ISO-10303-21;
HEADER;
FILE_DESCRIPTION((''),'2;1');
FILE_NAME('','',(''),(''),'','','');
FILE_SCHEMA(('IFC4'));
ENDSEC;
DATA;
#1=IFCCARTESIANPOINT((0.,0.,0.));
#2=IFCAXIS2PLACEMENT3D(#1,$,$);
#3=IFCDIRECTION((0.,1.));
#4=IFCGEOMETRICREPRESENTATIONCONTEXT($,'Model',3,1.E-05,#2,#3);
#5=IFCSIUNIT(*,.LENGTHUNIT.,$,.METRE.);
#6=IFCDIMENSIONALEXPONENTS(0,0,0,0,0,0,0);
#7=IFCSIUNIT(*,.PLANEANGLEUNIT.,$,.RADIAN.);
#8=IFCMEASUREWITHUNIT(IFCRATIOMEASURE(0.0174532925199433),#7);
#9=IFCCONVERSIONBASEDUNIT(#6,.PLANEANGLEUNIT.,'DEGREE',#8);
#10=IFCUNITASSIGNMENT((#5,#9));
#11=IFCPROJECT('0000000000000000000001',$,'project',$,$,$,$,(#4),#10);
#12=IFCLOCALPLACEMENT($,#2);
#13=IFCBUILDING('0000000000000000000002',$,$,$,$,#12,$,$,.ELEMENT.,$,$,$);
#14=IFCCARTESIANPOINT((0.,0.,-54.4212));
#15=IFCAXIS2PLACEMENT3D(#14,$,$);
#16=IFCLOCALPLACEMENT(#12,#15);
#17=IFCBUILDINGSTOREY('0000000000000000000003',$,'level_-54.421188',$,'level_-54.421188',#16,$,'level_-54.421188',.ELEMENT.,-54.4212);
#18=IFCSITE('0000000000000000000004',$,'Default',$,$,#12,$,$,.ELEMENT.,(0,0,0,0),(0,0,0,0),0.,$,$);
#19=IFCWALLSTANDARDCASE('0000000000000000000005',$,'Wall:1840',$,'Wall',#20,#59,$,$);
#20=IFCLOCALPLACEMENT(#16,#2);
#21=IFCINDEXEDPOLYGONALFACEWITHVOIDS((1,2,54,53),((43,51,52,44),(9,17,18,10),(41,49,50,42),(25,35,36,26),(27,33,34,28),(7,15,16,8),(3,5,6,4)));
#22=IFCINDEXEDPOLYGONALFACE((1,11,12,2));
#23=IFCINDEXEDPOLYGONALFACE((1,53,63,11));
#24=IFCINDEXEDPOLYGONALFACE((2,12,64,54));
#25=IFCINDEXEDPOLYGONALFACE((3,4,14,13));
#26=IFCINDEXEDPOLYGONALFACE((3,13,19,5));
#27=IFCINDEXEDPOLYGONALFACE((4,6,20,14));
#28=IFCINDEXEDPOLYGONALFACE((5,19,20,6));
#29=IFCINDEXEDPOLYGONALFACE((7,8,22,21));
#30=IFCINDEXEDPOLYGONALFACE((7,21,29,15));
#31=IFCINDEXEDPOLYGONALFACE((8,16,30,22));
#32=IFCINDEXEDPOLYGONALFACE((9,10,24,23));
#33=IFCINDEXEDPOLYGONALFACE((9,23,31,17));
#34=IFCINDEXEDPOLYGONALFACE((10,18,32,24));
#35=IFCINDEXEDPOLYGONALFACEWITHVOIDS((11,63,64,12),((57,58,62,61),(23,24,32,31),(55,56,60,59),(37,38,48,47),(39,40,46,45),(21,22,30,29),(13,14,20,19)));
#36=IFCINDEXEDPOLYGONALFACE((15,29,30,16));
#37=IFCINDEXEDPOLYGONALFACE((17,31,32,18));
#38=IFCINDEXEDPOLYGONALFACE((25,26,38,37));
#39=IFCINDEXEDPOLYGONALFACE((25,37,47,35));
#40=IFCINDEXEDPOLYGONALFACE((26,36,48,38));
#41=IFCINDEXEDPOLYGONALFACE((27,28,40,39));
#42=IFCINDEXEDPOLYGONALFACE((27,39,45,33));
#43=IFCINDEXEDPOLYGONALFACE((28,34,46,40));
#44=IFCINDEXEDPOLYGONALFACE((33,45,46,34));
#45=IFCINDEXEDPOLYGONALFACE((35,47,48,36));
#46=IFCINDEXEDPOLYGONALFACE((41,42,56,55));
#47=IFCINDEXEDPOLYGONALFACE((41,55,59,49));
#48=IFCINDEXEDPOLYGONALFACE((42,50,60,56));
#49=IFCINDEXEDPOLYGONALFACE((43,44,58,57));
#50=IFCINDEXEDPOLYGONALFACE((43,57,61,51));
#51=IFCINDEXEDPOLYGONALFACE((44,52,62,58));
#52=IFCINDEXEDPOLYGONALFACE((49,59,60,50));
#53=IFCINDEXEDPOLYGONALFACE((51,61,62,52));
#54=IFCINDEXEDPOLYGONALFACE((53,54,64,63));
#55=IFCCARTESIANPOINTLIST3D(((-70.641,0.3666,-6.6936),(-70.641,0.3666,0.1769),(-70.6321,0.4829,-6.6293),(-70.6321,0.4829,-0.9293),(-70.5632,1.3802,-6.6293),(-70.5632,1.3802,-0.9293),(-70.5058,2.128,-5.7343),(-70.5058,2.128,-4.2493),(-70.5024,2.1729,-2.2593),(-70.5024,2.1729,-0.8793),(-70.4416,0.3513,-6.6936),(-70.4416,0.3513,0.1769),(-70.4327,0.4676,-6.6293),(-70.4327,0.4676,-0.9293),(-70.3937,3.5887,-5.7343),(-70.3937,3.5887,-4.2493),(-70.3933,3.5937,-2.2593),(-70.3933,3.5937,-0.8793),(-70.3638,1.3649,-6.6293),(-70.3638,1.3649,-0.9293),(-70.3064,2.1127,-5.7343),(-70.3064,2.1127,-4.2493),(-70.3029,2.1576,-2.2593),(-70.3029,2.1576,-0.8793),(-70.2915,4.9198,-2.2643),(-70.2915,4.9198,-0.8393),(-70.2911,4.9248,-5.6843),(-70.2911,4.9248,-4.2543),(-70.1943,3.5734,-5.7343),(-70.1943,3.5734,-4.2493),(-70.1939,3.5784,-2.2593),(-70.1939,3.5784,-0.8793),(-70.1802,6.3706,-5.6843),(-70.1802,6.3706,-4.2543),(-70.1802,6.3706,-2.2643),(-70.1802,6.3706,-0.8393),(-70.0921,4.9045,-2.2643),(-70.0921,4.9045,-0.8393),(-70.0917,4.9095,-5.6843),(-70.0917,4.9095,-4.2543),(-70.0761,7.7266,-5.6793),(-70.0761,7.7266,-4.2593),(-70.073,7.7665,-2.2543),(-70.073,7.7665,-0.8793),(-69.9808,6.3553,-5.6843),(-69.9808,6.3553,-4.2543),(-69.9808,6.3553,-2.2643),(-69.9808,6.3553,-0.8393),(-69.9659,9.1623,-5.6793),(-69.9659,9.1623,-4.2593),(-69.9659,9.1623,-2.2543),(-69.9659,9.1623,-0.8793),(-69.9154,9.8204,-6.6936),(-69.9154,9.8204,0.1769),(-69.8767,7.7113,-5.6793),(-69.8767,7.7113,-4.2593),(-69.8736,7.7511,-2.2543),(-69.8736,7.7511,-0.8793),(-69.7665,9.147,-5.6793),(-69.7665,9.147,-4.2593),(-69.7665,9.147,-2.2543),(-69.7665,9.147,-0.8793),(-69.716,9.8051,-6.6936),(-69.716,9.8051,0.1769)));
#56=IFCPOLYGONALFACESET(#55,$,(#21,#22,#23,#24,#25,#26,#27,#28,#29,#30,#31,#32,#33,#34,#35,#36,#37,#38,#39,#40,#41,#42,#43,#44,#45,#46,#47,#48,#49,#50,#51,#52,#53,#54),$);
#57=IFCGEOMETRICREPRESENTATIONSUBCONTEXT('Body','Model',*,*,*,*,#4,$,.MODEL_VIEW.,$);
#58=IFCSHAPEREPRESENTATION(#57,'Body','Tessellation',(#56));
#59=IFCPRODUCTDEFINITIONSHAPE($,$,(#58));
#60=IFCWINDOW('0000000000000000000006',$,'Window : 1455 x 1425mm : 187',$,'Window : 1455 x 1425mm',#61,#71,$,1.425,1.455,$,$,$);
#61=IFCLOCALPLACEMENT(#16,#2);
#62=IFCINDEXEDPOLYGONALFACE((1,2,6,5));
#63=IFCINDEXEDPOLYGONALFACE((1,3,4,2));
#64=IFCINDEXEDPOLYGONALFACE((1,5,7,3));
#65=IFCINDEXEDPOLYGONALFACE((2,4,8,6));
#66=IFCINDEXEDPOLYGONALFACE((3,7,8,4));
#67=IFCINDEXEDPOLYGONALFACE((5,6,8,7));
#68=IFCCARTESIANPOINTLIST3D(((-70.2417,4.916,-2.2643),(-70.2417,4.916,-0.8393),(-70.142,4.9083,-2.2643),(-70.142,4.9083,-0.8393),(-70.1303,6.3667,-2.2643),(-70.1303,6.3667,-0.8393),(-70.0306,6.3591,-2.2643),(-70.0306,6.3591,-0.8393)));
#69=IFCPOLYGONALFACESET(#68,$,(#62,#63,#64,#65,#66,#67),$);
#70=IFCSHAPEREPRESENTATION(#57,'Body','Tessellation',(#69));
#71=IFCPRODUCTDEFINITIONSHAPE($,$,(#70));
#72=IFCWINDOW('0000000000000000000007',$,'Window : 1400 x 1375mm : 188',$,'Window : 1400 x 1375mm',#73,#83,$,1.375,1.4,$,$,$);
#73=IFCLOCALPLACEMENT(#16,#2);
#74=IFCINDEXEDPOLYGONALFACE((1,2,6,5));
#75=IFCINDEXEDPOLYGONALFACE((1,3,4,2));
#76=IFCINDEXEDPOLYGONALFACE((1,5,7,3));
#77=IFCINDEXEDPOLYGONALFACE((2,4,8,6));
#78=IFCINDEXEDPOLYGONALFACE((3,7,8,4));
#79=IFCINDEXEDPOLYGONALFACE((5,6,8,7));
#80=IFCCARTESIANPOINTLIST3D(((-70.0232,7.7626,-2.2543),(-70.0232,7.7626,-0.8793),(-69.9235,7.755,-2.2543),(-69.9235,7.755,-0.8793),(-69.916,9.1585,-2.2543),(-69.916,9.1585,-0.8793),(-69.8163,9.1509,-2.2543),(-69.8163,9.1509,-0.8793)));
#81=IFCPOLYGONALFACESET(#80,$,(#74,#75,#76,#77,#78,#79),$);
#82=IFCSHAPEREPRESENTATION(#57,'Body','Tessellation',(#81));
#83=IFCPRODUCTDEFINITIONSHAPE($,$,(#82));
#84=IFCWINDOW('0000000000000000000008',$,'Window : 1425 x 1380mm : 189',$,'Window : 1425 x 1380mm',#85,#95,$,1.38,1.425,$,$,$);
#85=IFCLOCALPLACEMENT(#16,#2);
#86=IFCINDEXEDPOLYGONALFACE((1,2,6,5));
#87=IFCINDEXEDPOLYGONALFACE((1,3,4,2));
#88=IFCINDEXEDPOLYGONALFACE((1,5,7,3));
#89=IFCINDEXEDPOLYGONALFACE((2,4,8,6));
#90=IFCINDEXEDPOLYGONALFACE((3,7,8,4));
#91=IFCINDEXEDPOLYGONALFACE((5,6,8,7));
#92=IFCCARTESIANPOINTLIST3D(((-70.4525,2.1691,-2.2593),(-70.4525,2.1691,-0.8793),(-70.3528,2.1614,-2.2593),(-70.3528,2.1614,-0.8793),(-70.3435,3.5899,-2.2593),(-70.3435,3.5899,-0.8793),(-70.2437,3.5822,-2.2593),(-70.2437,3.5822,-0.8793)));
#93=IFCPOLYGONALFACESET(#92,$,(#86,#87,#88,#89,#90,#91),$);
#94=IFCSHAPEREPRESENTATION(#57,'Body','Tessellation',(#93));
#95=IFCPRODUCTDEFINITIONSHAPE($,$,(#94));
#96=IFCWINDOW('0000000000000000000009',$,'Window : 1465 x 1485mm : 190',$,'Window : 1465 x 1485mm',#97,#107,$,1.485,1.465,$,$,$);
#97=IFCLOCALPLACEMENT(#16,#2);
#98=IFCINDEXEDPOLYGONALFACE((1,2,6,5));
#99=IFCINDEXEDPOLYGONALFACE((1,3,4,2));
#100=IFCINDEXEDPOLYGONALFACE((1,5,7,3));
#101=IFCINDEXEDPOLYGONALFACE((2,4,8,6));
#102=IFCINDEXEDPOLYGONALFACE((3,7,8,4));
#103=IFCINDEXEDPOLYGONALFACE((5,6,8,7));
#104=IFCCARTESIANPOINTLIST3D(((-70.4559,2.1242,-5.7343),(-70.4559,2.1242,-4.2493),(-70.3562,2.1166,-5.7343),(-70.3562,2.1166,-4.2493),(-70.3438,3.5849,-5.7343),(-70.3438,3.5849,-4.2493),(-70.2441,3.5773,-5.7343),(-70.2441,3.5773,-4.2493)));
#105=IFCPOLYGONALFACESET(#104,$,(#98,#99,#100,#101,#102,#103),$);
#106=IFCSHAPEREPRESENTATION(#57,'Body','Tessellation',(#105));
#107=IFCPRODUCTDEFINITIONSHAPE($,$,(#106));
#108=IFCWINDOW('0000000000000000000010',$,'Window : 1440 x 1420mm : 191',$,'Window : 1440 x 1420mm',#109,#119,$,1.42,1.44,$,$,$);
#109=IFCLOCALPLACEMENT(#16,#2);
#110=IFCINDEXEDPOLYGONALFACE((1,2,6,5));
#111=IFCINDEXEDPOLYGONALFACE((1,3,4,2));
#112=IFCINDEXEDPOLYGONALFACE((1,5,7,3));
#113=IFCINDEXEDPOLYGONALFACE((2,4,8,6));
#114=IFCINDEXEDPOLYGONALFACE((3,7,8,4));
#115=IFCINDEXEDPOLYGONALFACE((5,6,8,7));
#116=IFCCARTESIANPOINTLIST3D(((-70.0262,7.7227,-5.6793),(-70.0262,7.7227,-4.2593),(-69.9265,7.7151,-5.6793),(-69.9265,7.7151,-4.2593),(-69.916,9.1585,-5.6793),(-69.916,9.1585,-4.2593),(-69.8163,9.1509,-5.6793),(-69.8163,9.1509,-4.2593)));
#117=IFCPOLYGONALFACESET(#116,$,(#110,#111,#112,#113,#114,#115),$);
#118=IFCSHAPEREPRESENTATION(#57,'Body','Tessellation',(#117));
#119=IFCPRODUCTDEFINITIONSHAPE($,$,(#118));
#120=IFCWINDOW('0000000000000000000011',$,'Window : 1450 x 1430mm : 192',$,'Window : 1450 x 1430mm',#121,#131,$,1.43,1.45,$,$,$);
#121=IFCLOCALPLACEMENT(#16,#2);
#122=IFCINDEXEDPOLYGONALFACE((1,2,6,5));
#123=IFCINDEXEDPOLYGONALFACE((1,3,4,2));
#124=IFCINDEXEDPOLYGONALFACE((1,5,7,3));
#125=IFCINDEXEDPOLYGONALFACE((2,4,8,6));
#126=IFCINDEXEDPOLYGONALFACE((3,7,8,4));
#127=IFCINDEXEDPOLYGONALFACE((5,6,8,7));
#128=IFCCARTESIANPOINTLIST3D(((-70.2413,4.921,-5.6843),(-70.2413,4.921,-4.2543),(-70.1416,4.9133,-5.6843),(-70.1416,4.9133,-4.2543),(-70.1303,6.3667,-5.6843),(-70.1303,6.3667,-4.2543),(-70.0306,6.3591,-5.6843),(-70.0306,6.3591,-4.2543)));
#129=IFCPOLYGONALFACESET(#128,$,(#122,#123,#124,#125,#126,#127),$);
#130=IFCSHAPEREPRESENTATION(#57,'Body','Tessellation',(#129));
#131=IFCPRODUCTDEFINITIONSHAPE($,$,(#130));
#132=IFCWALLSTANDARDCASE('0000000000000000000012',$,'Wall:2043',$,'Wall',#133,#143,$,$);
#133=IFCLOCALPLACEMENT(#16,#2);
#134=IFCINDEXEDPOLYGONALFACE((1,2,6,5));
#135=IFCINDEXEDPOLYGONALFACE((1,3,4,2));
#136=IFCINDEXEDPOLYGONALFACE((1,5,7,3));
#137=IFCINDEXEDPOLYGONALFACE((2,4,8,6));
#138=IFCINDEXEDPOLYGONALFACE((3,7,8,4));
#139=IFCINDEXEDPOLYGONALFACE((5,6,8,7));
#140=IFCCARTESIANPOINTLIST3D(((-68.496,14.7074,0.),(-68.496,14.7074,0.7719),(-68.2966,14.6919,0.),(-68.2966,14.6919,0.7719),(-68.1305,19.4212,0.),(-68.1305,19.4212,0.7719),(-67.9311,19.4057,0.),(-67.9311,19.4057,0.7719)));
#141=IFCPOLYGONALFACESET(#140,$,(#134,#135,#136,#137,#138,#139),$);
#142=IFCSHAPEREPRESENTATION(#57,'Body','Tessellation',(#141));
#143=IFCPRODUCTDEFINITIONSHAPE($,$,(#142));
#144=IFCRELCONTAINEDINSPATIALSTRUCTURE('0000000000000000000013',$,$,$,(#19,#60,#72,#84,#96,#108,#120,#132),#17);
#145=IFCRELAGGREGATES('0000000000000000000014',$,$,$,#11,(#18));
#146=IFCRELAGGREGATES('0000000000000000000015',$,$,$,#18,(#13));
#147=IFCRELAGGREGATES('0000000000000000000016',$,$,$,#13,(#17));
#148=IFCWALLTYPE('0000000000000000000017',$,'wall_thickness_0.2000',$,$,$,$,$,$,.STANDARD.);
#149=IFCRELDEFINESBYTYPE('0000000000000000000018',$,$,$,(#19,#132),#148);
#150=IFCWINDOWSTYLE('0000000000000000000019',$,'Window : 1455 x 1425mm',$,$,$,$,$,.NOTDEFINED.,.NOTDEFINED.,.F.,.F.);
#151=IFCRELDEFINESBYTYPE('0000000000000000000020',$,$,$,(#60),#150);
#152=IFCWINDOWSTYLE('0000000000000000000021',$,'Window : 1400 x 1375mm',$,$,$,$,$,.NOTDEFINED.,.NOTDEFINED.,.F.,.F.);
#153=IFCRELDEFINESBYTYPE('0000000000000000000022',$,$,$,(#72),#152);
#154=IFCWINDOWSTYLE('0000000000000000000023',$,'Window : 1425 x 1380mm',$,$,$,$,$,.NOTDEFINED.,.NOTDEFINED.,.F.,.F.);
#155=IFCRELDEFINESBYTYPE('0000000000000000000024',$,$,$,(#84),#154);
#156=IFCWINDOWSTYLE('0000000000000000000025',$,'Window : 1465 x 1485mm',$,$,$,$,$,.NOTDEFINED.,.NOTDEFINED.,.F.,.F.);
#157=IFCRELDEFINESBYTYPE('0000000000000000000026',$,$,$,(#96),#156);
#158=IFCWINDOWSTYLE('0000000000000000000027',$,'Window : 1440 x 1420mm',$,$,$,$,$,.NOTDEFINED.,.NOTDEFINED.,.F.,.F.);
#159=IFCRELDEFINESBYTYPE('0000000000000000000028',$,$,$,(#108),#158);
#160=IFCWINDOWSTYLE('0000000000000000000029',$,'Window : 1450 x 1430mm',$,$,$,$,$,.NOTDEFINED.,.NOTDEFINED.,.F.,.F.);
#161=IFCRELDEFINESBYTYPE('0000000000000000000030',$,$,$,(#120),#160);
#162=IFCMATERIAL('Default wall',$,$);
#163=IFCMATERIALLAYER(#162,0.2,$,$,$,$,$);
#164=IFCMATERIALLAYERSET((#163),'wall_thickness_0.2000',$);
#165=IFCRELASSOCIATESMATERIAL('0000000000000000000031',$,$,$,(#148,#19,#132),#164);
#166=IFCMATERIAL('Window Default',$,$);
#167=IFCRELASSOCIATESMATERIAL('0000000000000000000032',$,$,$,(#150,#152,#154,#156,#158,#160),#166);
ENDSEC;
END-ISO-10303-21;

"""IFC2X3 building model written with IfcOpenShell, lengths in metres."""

from ifc_helpers import new_model, entity, si_unit, converted_unit, direction, frame, frame_2d, origin, origin_2d_with_axis, place, context, subcontext, project, spatial, polyline, rectangle, outline, extrude, source, transform, mapped, material, layer, layer_set, layer_usage, type_object, type_shapes, element, fill, save


model = new_model("IFC2X3")

# Units and contexts
model_context = context("Model", 3, precision=1e-05, world=origin(), true_north=direction((0.0, 1.0)))
body_context = subcontext(model_context, "Body", "Model", "MODEL_VIEW")
ifc_project = project(units=[si_unit("LENGTHUNIT", "METRE"), converted_unit("PLANEANGLEUNIT", "DEGREE", entity("IfcRatioMeasure", 0.0174532925199433), si_unit("PLANEANGLEUNIT", "RADIAN"), dimensions=[0, 0, 0, 0, 0, 0, 0])], contexts=[model_context])

# Site, building, storey
placement_1 = place(None, origin())
site = spatial("IfcSite", under=ifc_project, at=placement_1, Name="Default", CompositionType="ELEMENT", RefLatitude=(0, 0, 0, 0), RefLongitude=(0, 0, 0, 0), RefElevation=0.0)
building = spatial("IfcBuilding", under=site, at=placement_1, CompositionType="ELEMENT")
storey_placement = place(placement_1, frame((0.0, 0.0, -54.4212)))
storey = spatial("IfcBuildingStorey", under=building, at=storey_placement, Name="level_-54.421188", ObjectType="level_-54.421188", LongName="level_-54.421188", CompositionType="ELEMENT", Elevation=-54.4212)

# Shared definitions
ifc_material_1 = material(Name="Default wall")
ifc_layer = layer(ifc_material_1, 0.2)
ifc_layer_set = layer_set([ifc_layer], Name="wall_thickness_0.2000")
ifc_layer_usage = layer_usage(ifc_layer_set, "AXIS2", "POSITIVE", -0.1)
wall_type = type_object("IfcWallType", Name="wall_thickness_0.2000", PredefinedType="STANDARD", material=ifc_layer_set)

# Shared definitions
ifc_material_2 = material(Name="Window Default")

# Wall, openings, windows
placement_2 = place(placement_1, frame((0.0, 0.0, -61.1148)))
wall_1_placement = place(placement_2, frame((-69.8157, 9.8128, 0.0), z_axis=(0.0, 0.0, 1.0), x_axis=(-0.076528, -0.997067, 0.0)))
wall_1 = element("IfcWallStandardCase", 1, at=wall_1_placement, inside=storey, type_object=wall_type, material=ifc_layer_usage, Name="Wall:1840", ObjectType="Wall", context=body_context, shape_type="SweptSolid", body=[
    extrude(outline(polyline([(9.4816, -0.1), (9.4816, 0.1), (0.0, 0.1), (0.0, -0.1), (9.4816, -0.1)])), origin(), (0.0, 0.0, 1.0), 6.8705),
])
opening_1_placement = place(wall_1_placement, frame((8.465, -0.1, 0.0643)))
element("IfcOpeningElement", 2, at=opening_1_placement, cuts=wall_1, ObjectType="Opening", context=body_context, shape_type="SweptSolid", body=[
    extrude(rectangle(XDim=0.9, YDim=5.7, at=frame_2d((2.85, 0.45), x_axis=(0.0, 1.0))), frame((0.0, 0.0, 0.0), z_axis=(0.0, 1.0, 0.0), x_axis=(0.0, 0.0, 1.0)), (0.0, 0.0, 1.0), 0.2),
])
opening_2_placement = place(wall_1_placement, frame((3.46, -0.1, 4.4293)))
opening_2 = element("IfcOpeningElement", 3, at=opening_2_placement, cuts=wall_1, ObjectType="Opening", context=body_context, shape_type="SweptSolid", body=[
    extrude(rectangle(XDim=1.455, YDim=1.425, at=frame_2d((0.7125, 0.7275), x_axis=(0.0, 1.0))), frame((0.0, 0.0, 0.0), z_axis=(0.0, 1.0, 0.0), x_axis=(0.0, 0.0, 1.0)), (0.0, 0.0, 1.0), 0.2),
])
opening_3_placement = place(wall_1_placement, frame((0.66, -0.1, 4.4393)))
opening_3 = element("IfcOpeningElement", 4, at=opening_3_placement, cuts=wall_1, ObjectType="Opening", context=body_context, shape_type="SweptSolid", body=[
    extrude(rectangle(XDim=1.4, YDim=1.375, at=frame_2d((0.6875, 0.7), x_axis=(0.0, 1.0))), frame((0.0, 0.0, 0.0), z_axis=(0.0, 1.0, 0.0), x_axis=(0.0, 0.0, 1.0)), (0.0, 0.0, 1.0), 0.2),
])
opening_4_placement = place(wall_1_placement, frame((6.245, -0.1, 4.4343)))
opening_4 = element("IfcOpeningElement", 5, at=opening_4_placement, cuts=wall_1, ObjectType="Opening", context=body_context, shape_type="SweptSolid", body=[
    extrude(rectangle(XDim=1.425, YDim=1.38, at=frame_2d((0.69, 0.7125), x_axis=(0.0, 1.0))), frame((0.0, 0.0, 0.0), z_axis=(0.0, 1.0, 0.0), x_axis=(0.0, 0.0, 1.0)), (0.0, 0.0, 1.0), 0.2),
])
opening_5_placement = place(wall_1_placement, frame((6.25, -0.1, 0.9593)))
opening_5 = element("IfcOpeningElement", 6, at=opening_5_placement, cuts=wall_1, ObjectType="Opening", context=body_context, shape_type="SweptSolid", body=[
    extrude(rectangle(XDim=1.465, YDim=1.485, at=frame_2d((0.7425, 0.7325), x_axis=(0.0, 1.0))), frame((0.0, 0.0, 0.0), z_axis=(0.0, 1.0, 0.0), x_axis=(0.0, 0.0, 1.0)), (0.0, 0.0, 1.0), 0.2),
])
opening_6_placement = place(wall_1_placement, frame((0.66, -0.1, 1.0143)))
opening_6 = element("IfcOpeningElement", 7, at=opening_6_placement, cuts=wall_1, ObjectType="Opening", context=body_context, shape_type="SweptSolid", body=[
    extrude(rectangle(XDim=1.44, YDim=1.42, at=frame_2d((0.71, 0.72), x_axis=(0.0, 1.0))), frame((0.0, 0.0, 0.0), z_axis=(0.0, 1.0, 0.0), x_axis=(0.0, 0.0, 1.0)), (0.0, 0.0, 1.0), 0.2),
])
opening_7_placement = place(wall_1_placement, frame((3.46, -0.1, 1.0093)))
opening_7 = element("IfcOpeningElement", 8, at=opening_7_placement, cuts=wall_1, ObjectType="Opening", context=body_context, shape_type="SweptSolid", body=[
    extrude(rectangle(XDim=1.45, YDim=1.43, at=frame_2d((0.715, 0.725), x_axis=(0.0, 1.0))), frame((0.0, 0.0, 0.0), z_axis=(0.0, 1.0, 0.0), x_axis=(0.0, 0.0, 1.0)), (0.0, 0.0, 1.0), 0.2),
])
window_style_1 = type_object("IfcWindowStyle", Name="Window : 1455 x 1425mm", ConstructionType="NOTDEFINED", OperationType="NOTDEFINED", ParameterTakesPrecedence=False, Sizeable=False, material=ifc_material_2)
shared_shape_1 = source(origin(), body_context, "Body", "SweptSolid", [
    extrude(rectangle(XDim=0.1, YDim=1.455, at=origin_2d_with_axis()), frame((0.7275, 0.1, 0.0), z_axis=(0.0, 0.0, 1.0), x_axis=(0.0, 1.0, 0.0)), (0.0, 0.0, 1.0), 1.425),
])
type_shapes(window_style_1, [shared_shape_1])
window_1_placement = place(opening_2_placement, origin())
window_1 = element("IfcWindow", 9, at=window_1_placement, inside=storey, type_object=window_style_1, Name="Window : 1455 x 1425mm : 187", ObjectType="Window : 1455 x 1425mm", OverallHeight=1.425, OverallWidth=1.455, context=body_context, shape_type="MappedRepresentation", body=[
    mapped(shared_shape_1, transform((0.0, 0.0, 0.0), scale=1.0)),
])
fill(opening_2, window_1)
window_style_2 = type_object("IfcWindowStyle", Name="Window : 1400 x 1375mm", ConstructionType="NOTDEFINED", OperationType="NOTDEFINED", ParameterTakesPrecedence=False, Sizeable=False, material=ifc_material_2)
shared_shape_2 = source(origin(), body_context, "Body", "SweptSolid", [
    extrude(rectangle(XDim=0.1, YDim=1.4, at=origin_2d_with_axis()), frame((0.7, 0.1, 0.0), z_axis=(0.0, 0.0, 1.0), x_axis=(0.0, 1.0, 0.0)), (0.0, 0.0, 1.0), 1.375),
])
type_shapes(window_style_2, [shared_shape_2])
window_2_placement = place(opening_3_placement, origin())
window_2 = element("IfcWindow", 10, at=window_2_placement, inside=storey, type_object=window_style_2, Name="Window : 1400 x 1375mm : 188", ObjectType="Window : 1400 x 1375mm", OverallHeight=1.375, OverallWidth=1.4, context=body_context, shape_type="MappedRepresentation", body=[
    mapped(shared_shape_2, transform((0.0, 0.0, 0.0), scale=1.0)),
])
fill(opening_3, window_2)
window_style_3 = type_object("IfcWindowStyle", Name="Window : 1425 x 1380mm", ConstructionType="NOTDEFINED", OperationType="NOTDEFINED", ParameterTakesPrecedence=False, Sizeable=False, material=ifc_material_2)
shared_shape_3 = source(origin(), body_context, "Body", "SweptSolid", [
    extrude(rectangle(XDim=0.1, YDim=1.425, at=origin_2d_with_axis()), frame((0.7125, 0.1, 0.0), z_axis=(0.0, 0.0, 1.0), x_axis=(0.0, 1.0, 0.0)), (0.0, 0.0, 1.0), 1.38),
])
type_shapes(window_style_3, [shared_shape_3])
window_3_placement = place(opening_4_placement, origin())
window_3 = element("IfcWindow", 11, at=window_3_placement, inside=storey, type_object=window_style_3, Name="Window : 1425 x 1380mm : 189", ObjectType="Window : 1425 x 1380mm", OverallHeight=1.38, OverallWidth=1.425, context=body_context, shape_type="MappedRepresentation", body=[
    mapped(shared_shape_3, transform((0.0, 0.0, 0.0), scale=1.0)),
])
fill(opening_4, window_3)
window_style_4 = type_object("IfcWindowStyle", Name="Window : 1465 x 1485mm", ConstructionType="NOTDEFINED", OperationType="NOTDEFINED", ParameterTakesPrecedence=False, Sizeable=False, material=ifc_material_2)
shared_shape_4 = source(origin(), body_context, "Body", "SweptSolid", [
    extrude(rectangle(XDim=0.1, YDim=1.465, at=origin_2d_with_axis()), frame((0.7325, 0.1, 0.0), z_axis=(0.0, 0.0, 1.0), x_axis=(0.0, 1.0, 0.0)), (0.0, 0.0, 1.0), 1.485),
])
type_shapes(window_style_4, [shared_shape_4])
window_4_placement = place(opening_5_placement, origin())
window_4 = element("IfcWindow", 12, at=window_4_placement, inside=storey, type_object=window_style_4, Name="Window : 1465 x 1485mm : 190", ObjectType="Window : 1465 x 1485mm", OverallHeight=1.485, OverallWidth=1.465, context=body_context, shape_type="MappedRepresentation", body=[
    mapped(shared_shape_4, transform((0.0, 0.0, 0.0), scale=1.0)),
])
fill(opening_5, window_4)
window_style_5 = type_object("IfcWindowStyle", Name="Window : 1440 x 1420mm", ConstructionType="NOTDEFINED", OperationType="NOTDEFINED", ParameterTakesPrecedence=False, Sizeable=False, material=ifc_material_2)
shared_shape_5 = source(origin(), body_context, "Body", "SweptSolid", [
    extrude(rectangle(XDim=0.1, YDim=1.44, at=origin_2d_with_axis()), frame((0.72, 0.1, 0.0), z_axis=(0.0, 0.0, 1.0), x_axis=(0.0, 1.0, 0.0)), (0.0, 0.0, 1.0), 1.42),
])
type_shapes(window_style_5, [shared_shape_5])
window_5_placement = place(opening_6_placement, origin())
window_5 = element("IfcWindow", 13, at=window_5_placement, inside=storey, type_object=window_style_5, Name="Window : 1440 x 1420mm : 191", ObjectType="Window : 1440 x 1420mm", OverallHeight=1.42, OverallWidth=1.44, context=body_context, shape_type="MappedRepresentation", body=[
    mapped(shared_shape_5, transform((0.0, 0.0, 0.0), scale=1.0)),
])
fill(opening_6, window_5)
window_style_6 = type_object("IfcWindowStyle", Name="Window : 1450 x 1430mm", ConstructionType="NOTDEFINED", OperationType="NOTDEFINED", ParameterTakesPrecedence=False, Sizeable=False, material=ifc_material_2)
shared_shape_6 = source(origin(), body_context, "Body", "SweptSolid", [
    extrude(rectangle(XDim=0.1, YDim=1.45, at=origin_2d_with_axis()), frame((0.725, 0.1, 0.0), z_axis=(0.0, 0.0, 1.0), x_axis=(0.0, 1.0, 0.0)), (0.0, 0.0, 1.0), 1.43),
])
type_shapes(window_style_6, [shared_shape_6])
window_6_placement = place(opening_7_placement, origin())
window_6 = element("IfcWindow", 14, at=window_6_placement, inside=storey, type_object=window_style_6, Name="Window : 1450 x 1430mm : 192", ObjectType="Window : 1450 x 1430mm", OverallHeight=1.43, OverallWidth=1.45, context=body_context, shape_type="MappedRepresentation", body=[
    mapped(shared_shape_6, transform((0.0, 0.0, 0.0), scale=1.0)),
])
fill(opening_7, window_6)

# Wall
wall_2_placement = place(storey_placement, frame((-68.3963, 14.6996, 0.0), z_axis=(0.0, 0.0, 1.0), x_axis=(0.077296, 0.997008, 0.0)))
element("IfcWallStandardCase", 15, at=wall_2_placement, inside=storey, type_object=wall_type, material=ifc_layer_usage, Name="Wall:2043", ObjectType="Wall", context=body_context, shape_type="SweptSolid", body=[
    extrude(outline(polyline([(4.728, -0.1), (4.728, 0.1), (0.0, 0.1), (0.0, -0.1), (4.728, -0.1)])), origin(), (0.0, 0.0, 1.0), 0.7719),
])

save(model, "model.ifc")
